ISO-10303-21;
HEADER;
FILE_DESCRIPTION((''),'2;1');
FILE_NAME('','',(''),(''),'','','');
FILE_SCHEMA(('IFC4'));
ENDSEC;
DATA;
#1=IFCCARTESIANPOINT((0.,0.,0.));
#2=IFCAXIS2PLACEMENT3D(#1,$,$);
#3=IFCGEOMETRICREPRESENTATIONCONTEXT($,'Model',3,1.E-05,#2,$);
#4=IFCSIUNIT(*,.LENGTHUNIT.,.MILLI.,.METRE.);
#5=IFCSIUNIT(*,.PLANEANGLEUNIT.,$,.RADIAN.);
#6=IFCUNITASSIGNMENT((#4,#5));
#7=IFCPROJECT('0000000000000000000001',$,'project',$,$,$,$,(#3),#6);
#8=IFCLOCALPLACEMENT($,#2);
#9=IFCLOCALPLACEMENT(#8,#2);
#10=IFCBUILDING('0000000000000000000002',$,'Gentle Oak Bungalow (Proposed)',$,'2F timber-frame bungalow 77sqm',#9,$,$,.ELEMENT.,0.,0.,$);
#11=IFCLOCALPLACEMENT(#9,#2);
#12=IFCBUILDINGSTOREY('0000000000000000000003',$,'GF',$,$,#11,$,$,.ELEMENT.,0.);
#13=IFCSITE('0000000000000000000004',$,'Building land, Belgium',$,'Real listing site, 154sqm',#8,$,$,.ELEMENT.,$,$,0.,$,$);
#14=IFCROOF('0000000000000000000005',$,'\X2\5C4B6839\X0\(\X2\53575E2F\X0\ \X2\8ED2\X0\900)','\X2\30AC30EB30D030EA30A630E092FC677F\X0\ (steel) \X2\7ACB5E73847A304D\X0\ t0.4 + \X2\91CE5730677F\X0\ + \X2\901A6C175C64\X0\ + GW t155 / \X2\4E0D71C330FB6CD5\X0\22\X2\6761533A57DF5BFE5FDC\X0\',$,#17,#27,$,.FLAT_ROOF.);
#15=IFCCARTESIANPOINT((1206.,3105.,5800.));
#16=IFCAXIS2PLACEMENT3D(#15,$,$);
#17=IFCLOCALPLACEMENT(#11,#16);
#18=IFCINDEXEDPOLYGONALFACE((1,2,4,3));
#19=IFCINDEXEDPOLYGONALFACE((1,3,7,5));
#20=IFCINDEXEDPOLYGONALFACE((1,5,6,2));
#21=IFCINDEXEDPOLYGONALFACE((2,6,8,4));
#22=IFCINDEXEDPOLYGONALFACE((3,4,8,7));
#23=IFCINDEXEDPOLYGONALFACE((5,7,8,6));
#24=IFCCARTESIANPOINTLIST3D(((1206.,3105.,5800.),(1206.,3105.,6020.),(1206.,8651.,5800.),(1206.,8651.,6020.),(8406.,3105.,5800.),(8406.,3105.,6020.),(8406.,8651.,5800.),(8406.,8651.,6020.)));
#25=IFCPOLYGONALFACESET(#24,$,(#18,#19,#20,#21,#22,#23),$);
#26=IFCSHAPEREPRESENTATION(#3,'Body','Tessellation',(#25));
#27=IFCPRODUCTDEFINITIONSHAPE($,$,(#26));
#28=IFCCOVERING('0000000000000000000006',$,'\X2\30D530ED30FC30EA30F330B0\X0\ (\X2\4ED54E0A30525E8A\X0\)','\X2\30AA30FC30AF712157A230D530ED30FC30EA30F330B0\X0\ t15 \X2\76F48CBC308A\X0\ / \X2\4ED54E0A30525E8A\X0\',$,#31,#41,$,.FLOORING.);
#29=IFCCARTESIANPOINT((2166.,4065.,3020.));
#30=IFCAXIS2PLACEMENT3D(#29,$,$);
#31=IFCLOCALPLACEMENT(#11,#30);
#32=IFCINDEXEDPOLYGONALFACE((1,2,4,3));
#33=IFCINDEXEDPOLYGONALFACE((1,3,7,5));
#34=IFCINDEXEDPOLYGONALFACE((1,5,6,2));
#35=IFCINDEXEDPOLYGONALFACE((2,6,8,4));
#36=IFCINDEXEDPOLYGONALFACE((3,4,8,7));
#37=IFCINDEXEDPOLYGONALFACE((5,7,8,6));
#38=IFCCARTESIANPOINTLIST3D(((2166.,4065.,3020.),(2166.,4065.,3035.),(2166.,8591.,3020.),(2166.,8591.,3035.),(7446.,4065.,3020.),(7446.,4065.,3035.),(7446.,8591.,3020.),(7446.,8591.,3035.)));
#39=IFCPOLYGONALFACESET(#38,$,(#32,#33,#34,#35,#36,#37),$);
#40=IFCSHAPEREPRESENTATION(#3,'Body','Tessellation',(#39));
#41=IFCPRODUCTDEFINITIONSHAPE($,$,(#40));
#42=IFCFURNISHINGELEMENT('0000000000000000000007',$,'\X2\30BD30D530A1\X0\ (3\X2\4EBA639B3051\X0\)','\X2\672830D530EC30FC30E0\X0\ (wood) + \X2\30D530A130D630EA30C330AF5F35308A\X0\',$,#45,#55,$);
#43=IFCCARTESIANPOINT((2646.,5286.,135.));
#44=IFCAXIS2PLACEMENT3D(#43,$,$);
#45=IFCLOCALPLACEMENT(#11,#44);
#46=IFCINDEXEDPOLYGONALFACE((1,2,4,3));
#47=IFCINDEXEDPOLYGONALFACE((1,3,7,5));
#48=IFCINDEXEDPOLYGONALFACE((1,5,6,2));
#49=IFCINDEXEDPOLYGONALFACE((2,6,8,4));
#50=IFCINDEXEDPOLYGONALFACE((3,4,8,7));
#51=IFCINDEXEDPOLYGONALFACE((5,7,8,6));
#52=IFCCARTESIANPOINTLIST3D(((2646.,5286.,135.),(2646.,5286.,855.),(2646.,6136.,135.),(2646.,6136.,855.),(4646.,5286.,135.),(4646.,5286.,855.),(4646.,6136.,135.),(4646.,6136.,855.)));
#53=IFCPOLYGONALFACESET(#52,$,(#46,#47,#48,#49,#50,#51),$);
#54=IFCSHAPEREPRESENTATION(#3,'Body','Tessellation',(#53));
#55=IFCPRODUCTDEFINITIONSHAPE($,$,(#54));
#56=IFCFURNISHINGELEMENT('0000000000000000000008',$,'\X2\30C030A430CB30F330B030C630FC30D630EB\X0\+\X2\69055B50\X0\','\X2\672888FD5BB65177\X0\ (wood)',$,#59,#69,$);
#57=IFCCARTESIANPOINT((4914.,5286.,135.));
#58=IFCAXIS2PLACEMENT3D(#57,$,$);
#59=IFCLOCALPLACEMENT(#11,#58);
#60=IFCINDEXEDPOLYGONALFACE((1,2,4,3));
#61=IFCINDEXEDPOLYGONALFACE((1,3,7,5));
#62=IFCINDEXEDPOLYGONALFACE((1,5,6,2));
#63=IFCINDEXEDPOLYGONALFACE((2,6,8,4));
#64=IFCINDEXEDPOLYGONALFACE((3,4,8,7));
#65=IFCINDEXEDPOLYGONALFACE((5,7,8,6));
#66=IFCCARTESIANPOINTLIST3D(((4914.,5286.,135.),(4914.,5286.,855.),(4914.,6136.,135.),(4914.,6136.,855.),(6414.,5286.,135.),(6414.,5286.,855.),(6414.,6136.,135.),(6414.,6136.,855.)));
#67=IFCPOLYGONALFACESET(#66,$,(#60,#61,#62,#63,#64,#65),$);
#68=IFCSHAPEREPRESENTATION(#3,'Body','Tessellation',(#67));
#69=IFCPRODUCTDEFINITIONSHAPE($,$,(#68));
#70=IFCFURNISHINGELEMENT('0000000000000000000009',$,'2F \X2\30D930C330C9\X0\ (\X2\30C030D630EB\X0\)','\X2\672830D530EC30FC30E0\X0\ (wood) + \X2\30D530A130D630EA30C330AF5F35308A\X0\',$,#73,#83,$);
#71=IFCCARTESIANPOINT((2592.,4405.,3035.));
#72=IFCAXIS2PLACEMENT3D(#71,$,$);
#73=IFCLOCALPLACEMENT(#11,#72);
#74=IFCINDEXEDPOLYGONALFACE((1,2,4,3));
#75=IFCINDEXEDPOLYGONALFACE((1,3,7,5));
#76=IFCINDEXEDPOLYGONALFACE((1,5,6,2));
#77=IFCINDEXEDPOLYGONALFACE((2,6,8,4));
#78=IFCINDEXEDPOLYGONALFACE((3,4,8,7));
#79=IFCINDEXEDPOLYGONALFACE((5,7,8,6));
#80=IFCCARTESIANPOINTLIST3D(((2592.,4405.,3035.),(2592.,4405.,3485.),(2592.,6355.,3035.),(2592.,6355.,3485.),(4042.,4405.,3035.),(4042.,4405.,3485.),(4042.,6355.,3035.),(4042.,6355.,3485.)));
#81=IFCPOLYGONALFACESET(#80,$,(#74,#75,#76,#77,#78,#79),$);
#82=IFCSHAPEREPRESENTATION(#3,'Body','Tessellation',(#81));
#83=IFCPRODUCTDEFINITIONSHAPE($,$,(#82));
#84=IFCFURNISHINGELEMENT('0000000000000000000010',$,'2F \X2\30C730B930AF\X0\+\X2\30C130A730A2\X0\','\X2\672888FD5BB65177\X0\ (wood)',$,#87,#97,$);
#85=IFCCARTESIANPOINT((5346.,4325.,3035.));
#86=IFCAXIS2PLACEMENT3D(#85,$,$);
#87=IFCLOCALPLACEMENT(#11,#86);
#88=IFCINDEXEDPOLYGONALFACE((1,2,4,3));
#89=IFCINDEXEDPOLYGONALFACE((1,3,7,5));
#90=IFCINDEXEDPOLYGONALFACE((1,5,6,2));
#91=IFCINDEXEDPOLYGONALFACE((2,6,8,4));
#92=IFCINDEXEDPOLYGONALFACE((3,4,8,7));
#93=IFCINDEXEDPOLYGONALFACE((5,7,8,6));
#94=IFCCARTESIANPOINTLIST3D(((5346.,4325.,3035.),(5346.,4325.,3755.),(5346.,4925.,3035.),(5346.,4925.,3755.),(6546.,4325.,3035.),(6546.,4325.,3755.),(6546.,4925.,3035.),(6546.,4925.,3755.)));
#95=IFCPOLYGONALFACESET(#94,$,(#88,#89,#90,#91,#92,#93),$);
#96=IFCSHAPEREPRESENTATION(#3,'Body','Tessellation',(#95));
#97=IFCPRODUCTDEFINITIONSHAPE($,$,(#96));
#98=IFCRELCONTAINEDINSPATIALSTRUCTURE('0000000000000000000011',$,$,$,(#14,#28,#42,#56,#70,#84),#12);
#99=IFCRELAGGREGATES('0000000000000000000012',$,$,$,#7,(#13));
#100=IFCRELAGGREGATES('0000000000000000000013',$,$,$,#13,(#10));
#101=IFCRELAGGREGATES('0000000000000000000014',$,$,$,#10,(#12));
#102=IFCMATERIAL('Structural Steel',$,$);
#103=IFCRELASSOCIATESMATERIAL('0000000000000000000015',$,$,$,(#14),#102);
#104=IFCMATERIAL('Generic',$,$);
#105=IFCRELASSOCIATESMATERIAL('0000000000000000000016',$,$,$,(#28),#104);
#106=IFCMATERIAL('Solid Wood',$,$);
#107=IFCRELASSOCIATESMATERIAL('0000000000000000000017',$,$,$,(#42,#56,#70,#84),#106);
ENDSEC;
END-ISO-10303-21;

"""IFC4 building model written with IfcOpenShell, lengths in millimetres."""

from ifc_helpers import new_model, si_unit, frame, frame_2d, origin, place, context, project, spatial, rectangle, extrude, material, element, save


model = new_model("IFC4")

# Units and contexts
model_context = context("Model", 3, precision=1e-05, world=origin())
ifc_project = project(units=[si_unit("LENGTHUNIT", "METRE", prefix="MILLI"), si_unit("PLANEANGLEUNIT", "RADIAN")], contexts=[model_context])

# Site, building, storey
site_placement = place(None, origin())
site = spatial("IfcSite", under=ifc_project, at=site_placement, Name="Building land, Belgium", ObjectType="Real listing site, 154sqm", CompositionType="ELEMENT", RefElevation=0.0)
building_placement = place(site_placement, origin())
building = spatial("IfcBuilding", under=site, at=building_placement, Name="Gentle Oak Bungalow (Proposed)", ObjectType="2F timber-frame bungalow 77sqm", CompositionType="ELEMENT", ElevationOfRefHeight=0.0, ElevationOfTerrain=0.0)
storey_placement = place(building_placement, origin())
storey = spatial("IfcBuildingStorey", under=building, at=storey_placement, Name="GF", CompositionType="ELEMENT", Elevation=0.0)

# Shared definitions
ifc_material_1 = material(Name="Solid Wood")

# Roof
ifc_material_2 = material(Name="Structural Steel")
for number, where, name in (
    (1, (1206.0, 3105.0, 5800.0), "屋根(南帯 軒900)"),
):
    element("IfcRoof", number, at=place(storey_placement, frame(where)), inside=storey, material=ifc_material_2, Name=name, Description="ガルバリウム鋼板 (steel) 立平葺き t0.4 + 野地板 + 通気層 + GW t155 / 不燃・法22条区域対応", PredefinedType="FLAT_ROOF", context=model_context, shape_type="SweptSolid", body=[
        extrude(rectangle(XDim=7200.0, YDim=5546.0, at=frame_2d((3600.0, 2773.0))), frame((1206.0, 3105.0, 5800.0)), (0.0, 0.0, 1.0), 220.0),
    ])

# Covering
ifc_material_3 = material(Name="Generic")
covering_placement = place(storey_placement, frame((2166.0, 4065.0, 3020.0)))
element("IfcCovering", 2, at=covering_placement, inside=storey, material=ifc_material_3, Name="フローリング (仕上げ床)", Description="オーク無垢フローリング t15 直貼り / 仕上げ床", PredefinedType="FLOORING", context=model_context, shape_type="SweptSolid", body=[
    extrude(rectangle(XDim=5280.0, YDim=4526.0, at=frame_2d((2640.0, 2263.0))), frame((2166.0, 4065.0, 3020.0)), (0.0, 0.0, 1.0), 15.0),
])

# Furnishing elements
furnishing_1_placement = place(storey_placement, frame((2646.0, 5286.0, 135.0)))
element("IfcFurnishingElement", 3, at=furnishing_1_placement, inside=storey, material=ifc_material_1, Name="ソファ (3人掛け)", Description="木フレーム (wood) + ファブリック張り", context=model_context, shape_type="SweptSolid", body=[
    extrude(rectangle(XDim=2000.0, YDim=850.0, at=frame_2d((1000.0, 425.0))), frame((2646.0, 5286.0, 135.0)), (0.0, 0.0, 1.0), 720.0),
])
furnishing_2_placement = place(storey_placement, frame((4914.0, 5286.0, 135.0)))
element("IfcFurnishingElement", 4, at=furnishing_2_placement, inside=storey, material=ifc_material_1, Name="ダイニングテーブル+椅子", Description="木製家具 (wood)", context=model_context, shape_type="SweptSolid", body=[
    extrude(rectangle(XDim=1500.0, YDim=850.0, at=frame_2d((750.0, 425.0))), frame((4914.0, 5286.0, 135.0)), (0.0, 0.0, 1.0), 720.0),
])
furnishing_3_placement = place(storey_placement, frame((2592.0, 4405.0, 3035.0)))
element("IfcFurnishingElement", 5, at=furnishing_3_placement, inside=storey, material=ifc_material_1, Name="2F ベッド (ダブル)", Description="木フレーム (wood) + ファブリック張り", context=model_context, shape_type="SweptSolid", body=[
    extrude(rectangle(XDim=1450.0, YDim=1950.0, at=frame_2d((725.0, 975.0))), frame((2592.0, 4405.0, 3035.0)), (0.0, 0.0, 1.0), 450.0),
])
furnishing_4_placement = place(storey_placement, frame((5346.0, 4325.0, 3035.0)))
element("IfcFurnishingElement", 6, at=furnishing_4_placement, inside=storey, material=ifc_material_1, Name="2F デスク+チェア", Description="木製家具 (wood)", context=model_context, shape_type="SweptSolid", body=[
    extrude(rectangle(XDim=1200.0, YDim=600.0, at=frame_2d((600.0, 300.0))), frame((5346.0, 4325.0, 3035.0)), (0.0, 0.0, 1.0), 720.0),
])

save(model, "model.ifc")
